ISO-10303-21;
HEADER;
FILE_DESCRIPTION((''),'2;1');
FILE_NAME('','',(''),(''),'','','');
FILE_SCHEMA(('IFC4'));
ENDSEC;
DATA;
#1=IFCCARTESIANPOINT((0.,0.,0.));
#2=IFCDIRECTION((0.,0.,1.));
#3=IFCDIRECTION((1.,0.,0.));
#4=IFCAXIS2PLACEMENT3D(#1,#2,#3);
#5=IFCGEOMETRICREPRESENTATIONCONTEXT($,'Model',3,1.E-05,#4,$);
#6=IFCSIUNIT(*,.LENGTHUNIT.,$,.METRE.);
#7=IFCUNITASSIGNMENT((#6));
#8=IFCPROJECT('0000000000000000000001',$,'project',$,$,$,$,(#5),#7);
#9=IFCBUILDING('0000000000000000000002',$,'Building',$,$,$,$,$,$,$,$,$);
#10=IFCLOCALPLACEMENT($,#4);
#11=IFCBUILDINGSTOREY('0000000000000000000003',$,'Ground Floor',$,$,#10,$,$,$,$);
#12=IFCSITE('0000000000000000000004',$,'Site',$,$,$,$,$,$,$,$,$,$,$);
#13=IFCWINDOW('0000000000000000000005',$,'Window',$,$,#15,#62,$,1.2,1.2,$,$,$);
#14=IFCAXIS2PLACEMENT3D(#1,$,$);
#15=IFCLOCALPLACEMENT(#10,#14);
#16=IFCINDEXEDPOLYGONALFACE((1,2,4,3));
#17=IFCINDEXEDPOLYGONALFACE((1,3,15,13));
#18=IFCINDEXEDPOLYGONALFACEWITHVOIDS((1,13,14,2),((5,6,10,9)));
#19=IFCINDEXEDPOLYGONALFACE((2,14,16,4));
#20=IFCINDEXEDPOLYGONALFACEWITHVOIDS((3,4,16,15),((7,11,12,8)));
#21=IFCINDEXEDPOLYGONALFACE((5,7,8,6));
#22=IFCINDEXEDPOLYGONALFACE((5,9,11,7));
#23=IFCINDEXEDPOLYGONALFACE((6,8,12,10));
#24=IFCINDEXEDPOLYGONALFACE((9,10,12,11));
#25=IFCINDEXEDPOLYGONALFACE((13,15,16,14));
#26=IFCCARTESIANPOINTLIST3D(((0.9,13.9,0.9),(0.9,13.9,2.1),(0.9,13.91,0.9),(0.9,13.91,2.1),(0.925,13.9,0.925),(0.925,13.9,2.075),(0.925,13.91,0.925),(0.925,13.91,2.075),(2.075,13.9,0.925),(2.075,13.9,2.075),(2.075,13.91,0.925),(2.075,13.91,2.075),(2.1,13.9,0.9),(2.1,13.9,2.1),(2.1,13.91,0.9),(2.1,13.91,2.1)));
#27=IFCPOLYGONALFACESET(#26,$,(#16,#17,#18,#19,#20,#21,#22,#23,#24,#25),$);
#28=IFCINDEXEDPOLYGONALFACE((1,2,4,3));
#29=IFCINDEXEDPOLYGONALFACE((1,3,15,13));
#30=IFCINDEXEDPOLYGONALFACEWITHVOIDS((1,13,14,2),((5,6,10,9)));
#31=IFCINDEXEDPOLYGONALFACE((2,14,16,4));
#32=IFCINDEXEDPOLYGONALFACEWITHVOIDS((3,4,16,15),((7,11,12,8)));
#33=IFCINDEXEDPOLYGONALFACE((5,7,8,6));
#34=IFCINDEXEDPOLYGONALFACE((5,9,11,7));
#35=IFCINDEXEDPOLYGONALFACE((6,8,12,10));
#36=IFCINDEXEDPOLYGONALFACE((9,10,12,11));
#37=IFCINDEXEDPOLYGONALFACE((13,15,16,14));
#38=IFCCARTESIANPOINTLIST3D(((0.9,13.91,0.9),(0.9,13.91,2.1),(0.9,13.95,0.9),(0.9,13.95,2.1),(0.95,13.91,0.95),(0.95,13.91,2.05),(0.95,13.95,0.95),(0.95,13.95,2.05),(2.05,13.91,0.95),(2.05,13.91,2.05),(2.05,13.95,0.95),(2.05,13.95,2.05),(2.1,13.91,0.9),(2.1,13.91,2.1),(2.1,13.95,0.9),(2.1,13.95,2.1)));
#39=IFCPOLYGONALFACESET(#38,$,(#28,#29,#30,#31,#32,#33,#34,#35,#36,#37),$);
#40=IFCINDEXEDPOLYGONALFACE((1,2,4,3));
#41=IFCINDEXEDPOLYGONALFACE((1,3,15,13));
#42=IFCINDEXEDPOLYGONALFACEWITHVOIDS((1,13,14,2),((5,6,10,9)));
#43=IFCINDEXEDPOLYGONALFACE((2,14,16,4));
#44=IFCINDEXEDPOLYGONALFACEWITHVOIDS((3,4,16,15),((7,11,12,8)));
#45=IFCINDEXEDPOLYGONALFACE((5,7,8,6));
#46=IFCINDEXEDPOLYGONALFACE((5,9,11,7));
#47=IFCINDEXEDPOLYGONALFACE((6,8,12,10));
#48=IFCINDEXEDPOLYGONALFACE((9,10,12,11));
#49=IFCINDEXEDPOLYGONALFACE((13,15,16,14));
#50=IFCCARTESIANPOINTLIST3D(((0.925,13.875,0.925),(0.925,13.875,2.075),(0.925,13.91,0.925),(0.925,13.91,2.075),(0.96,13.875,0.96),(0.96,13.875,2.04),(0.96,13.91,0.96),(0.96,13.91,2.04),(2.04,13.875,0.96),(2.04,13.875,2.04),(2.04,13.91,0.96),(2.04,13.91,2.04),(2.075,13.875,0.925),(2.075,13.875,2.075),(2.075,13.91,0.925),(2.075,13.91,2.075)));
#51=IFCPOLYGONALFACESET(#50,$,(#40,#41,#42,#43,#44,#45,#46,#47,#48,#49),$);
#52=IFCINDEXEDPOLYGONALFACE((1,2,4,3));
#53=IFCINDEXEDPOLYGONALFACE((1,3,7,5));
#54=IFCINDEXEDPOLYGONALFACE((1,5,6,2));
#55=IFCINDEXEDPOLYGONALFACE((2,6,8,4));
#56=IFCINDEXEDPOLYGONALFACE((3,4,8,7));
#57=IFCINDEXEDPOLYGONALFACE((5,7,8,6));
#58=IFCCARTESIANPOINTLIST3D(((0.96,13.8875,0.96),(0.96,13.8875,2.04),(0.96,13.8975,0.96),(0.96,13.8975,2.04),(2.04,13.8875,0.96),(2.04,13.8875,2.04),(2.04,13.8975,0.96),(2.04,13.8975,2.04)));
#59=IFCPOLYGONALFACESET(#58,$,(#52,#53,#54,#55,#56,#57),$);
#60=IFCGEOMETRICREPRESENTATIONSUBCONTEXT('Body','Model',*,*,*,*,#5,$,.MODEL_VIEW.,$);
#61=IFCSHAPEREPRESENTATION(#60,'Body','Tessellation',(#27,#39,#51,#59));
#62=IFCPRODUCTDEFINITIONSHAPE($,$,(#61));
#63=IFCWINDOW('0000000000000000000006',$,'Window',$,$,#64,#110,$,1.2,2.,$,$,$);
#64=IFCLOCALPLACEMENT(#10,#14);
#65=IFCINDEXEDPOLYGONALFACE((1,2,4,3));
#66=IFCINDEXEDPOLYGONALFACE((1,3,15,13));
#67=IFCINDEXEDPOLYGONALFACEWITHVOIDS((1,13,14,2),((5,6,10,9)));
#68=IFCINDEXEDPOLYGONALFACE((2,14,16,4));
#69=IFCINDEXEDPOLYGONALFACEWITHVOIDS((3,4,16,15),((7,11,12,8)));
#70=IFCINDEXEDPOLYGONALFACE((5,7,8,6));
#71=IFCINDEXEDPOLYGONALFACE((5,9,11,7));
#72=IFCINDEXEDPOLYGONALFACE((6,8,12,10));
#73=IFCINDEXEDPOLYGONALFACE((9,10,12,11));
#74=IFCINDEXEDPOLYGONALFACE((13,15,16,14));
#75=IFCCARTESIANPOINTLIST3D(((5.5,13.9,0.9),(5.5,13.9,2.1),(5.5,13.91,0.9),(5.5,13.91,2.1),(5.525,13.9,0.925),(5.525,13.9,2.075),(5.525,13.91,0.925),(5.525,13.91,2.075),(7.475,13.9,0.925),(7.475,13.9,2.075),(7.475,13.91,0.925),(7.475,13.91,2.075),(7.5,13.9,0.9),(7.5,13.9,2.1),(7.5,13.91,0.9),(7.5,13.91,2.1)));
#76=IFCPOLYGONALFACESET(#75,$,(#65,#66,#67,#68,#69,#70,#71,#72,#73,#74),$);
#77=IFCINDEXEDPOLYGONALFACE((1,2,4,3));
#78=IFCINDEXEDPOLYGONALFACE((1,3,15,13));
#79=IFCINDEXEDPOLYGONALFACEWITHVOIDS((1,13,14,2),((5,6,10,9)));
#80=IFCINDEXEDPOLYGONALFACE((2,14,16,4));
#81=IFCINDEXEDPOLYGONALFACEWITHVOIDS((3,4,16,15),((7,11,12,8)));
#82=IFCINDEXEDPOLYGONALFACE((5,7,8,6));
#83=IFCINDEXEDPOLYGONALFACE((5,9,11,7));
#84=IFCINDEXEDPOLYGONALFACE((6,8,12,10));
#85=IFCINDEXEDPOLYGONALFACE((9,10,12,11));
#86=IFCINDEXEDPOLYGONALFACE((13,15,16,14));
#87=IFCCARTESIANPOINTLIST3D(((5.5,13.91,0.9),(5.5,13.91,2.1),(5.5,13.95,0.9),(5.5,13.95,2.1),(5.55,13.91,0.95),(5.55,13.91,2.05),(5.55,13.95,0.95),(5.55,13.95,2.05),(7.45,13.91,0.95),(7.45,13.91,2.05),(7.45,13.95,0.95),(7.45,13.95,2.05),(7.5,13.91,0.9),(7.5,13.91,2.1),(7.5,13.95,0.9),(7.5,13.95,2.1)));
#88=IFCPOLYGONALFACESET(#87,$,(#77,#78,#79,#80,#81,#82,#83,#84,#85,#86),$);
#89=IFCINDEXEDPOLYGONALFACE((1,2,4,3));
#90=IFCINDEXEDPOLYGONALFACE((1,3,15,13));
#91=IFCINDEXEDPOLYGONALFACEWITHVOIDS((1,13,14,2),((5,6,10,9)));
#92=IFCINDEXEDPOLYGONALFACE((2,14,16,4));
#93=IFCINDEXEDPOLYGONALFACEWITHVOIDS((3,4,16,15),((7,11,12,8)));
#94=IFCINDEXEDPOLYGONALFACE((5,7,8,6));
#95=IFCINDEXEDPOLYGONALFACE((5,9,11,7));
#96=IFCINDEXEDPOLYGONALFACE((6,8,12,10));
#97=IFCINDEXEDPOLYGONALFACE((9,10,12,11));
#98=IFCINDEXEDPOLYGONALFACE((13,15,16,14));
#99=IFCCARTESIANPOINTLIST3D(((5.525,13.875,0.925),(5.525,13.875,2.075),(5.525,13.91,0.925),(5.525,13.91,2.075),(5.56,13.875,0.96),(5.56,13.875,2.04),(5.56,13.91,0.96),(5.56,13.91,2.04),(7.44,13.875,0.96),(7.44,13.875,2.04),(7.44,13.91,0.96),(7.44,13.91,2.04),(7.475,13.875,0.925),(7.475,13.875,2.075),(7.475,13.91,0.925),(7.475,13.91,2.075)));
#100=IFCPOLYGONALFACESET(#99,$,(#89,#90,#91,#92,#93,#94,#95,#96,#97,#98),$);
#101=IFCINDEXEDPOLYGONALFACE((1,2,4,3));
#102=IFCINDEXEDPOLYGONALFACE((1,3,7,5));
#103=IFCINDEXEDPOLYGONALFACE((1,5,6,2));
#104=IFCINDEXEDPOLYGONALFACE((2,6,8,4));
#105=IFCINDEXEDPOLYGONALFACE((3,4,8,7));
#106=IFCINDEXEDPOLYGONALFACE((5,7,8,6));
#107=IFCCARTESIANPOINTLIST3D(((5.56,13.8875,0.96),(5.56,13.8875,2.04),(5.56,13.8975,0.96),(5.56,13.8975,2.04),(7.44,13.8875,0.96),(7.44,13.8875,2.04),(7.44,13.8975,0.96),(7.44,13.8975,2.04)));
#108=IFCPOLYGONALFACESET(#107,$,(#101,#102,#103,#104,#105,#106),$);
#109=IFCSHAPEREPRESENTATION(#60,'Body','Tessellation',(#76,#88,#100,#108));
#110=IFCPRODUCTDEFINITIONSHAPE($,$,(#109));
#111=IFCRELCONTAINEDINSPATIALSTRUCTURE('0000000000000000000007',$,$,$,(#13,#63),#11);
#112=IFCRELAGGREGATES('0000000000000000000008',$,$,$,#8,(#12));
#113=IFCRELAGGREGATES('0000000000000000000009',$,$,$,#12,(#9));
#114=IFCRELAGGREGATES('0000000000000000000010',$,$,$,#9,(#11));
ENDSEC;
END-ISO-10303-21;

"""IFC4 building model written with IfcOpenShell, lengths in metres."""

from ifc_helpers import new_model, si_unit, frame, origin_with_axes, place, context, subcontext, project, spatial, line, indexed_curve, outline, extrude, element, save


model = new_model("IFC4")

# Units and contexts
model_context = context("Model", 3, precision=1e-05, world=origin_with_axes())
body_context = subcontext(model_context, "Body", "Model", "MODEL_VIEW")
ifc_project = project(units=[si_unit("LENGTHUNIT", "METRE")], contexts=[model_context])

# Site, building, storey
site = spatial("IfcSite", under=ifc_project, Name="Site")
building = spatial("IfcBuilding", under=site, Name="Building")
storey_placement = place(None, origin_with_axes())
storey = spatial("IfcBuildingStorey", under=building, at=storey_placement, Name="Ground Floor")

# Windows
for number, where, z_axis, x_axis, name in (
    (1, (2.1, 14.0, 0.9), (0.0, 0.0, 1.0), (-1.0, 0.0, 0.0), "Window"),
):
    element("IfcWindow", number, at=place(storey_placement, frame(where, z_axis=z_axis, x_axis=x_axis)), inside=storey, Name=name, OverallHeight=1.2, OverallWidth=1.2, context=body_context, shape_type="SweptSolid", body=[
        extrude(outline(indexed_curve([(0.0, 0.0), (1.2, 0.0), (1.2, 1.2), (0.0, 1.2)], segments=[line(1, 2, 3, 4, 1)]), holes=[indexed_curve([(0.025, 0.025), (1.175, 0.025), (1.175, 1.175), (0.025, 1.175)], segments=[line(1, 2, 3, 4, 1)])]), frame((0.0, 0.09, 0.0), z_axis=(0.0, -1.0, 0.0), x_axis=(1.0, 0.0, 0.0)), (0.0, 0.0, -1.0), 0.01),
        extrude(outline(indexed_curve([(0.0, 0.0), (1.2, 0.0), (1.2, 1.2), (0.0, 1.2)], segments=[line(1, 2, 3, 4, 1)]), holes=[indexed_curve([(0.05, 0.05), (1.15, 0.05), (1.15, 1.15), (0.05, 1.15)], segments=[line(1, 2, 3, 4, 1)])]), frame((0.0, 0.05, 0.0), z_axis=(0.0, -1.0, 0.0), x_axis=(1.0, 0.0, 0.0)), (0.0, 0.0, -1.0), 0.04),
        extrude(outline(indexed_curve([(0.0, 0.0), (1.15, 0.0), (1.15, 1.15), (0.0, 1.15)], segments=[line(1, 2, 3, 4, 1)]), holes=[indexed_curve([(0.035, 0.035), (1.115, 0.035), (1.115, 1.115), (0.035, 1.115)], segments=[line(1, 2, 3, 4, 1)])]), frame((0.025, 0.09, 0.025), z_axis=(0.0, -1.0, 0.0), x_axis=(1.0, 0.0, 0.0)), (0.0, 0.0, -1.0), 0.035),
        extrude(outline(indexed_curve([(0.035, 0.035), (1.115, 0.035), (1.115, 1.115), (0.035, 1.115)], segments=[line(1, 2, 3, 4, 1)])), frame((0.025, 0.1025, 0.025), z_axis=(0.0, -1.0, 0.0), x_axis=(1.0, 0.0, 0.0)), (0.0, 0.0, -1.0), 0.01),
    ])
window_1_placement = place(storey_placement, frame((7.5, 14.0, 0.9), z_axis=(0.0, 0.0, 1.0), x_axis=(-1.0, 0.0, 0.0)))
element("IfcWindow", 2, at=window_1_placement, inside=storey, Name="Window", OverallHeight=1.2, OverallWidth=2.0, context=body_context, shape_type="SweptSolid", body=[
    extrude(outline(indexed_curve([(0.0, 0.0), (2.0, 0.0), (2.0, 1.2), (0.0, 1.2)], segments=[line(1, 2, 3, 4, 1)]), holes=[indexed_curve([(0.025, 0.025), (1.975, 0.025), (1.975, 1.175), (0.025, 1.175)], segments=[line(1, 2, 3, 4, 1)])]), frame((0.0, 0.09, 0.0), z_axis=(0.0, -1.0, 0.0), x_axis=(1.0, 0.0, 0.0)), (0.0, 0.0, -1.0), 0.01),
    extrude(outline(indexed_curve([(0.0, 0.0), (2.0, 0.0), (2.0, 1.2), (0.0, 1.2)], segments=[line(1, 2, 3, 4, 1)]), holes=[indexed_curve([(0.05, 0.05), (1.95, 0.05), (1.95, 1.15), (0.05, 1.15)], segments=[line(1, 2, 3, 4, 1)])]), frame((0.0, 0.05, 0.0), z_axis=(0.0, -1.0, 0.0), x_axis=(1.0, 0.0, 0.0)), (0.0, 0.0, -1.0), 0.04),
    extrude(outline(indexed_curve([(0.0, 0.0), (1.95, 0.0), (1.95, 1.15), (0.0, 1.15)], segments=[line(1, 2, 3, 4, 1)]), holes=[indexed_curve([(0.035, 0.035), (1.915, 0.035), (1.915, 1.115), (0.035, 1.115)], segments=[line(1, 2, 3, 4, 1)])]), frame((0.025, 0.09, 0.025), z_axis=(0.0, -1.0, 0.0), x_axis=(1.0, 0.0, 0.0)), (0.0, 0.0, -1.0), 0.035),
    extrude(outline(indexed_curve([(0.035, 0.035), (1.915, 0.035), (1.915, 1.115), (0.035, 1.115)], segments=[line(1, 2, 3, 4, 1)])), frame((0.025, 0.1025, 0.025), z_axis=(0.0, -1.0, 0.0), x_axis=(1.0, 0.0, 0.0)), (0.0, 0.0, -1.0), 0.01),
])

save(model, "model.ifc")
